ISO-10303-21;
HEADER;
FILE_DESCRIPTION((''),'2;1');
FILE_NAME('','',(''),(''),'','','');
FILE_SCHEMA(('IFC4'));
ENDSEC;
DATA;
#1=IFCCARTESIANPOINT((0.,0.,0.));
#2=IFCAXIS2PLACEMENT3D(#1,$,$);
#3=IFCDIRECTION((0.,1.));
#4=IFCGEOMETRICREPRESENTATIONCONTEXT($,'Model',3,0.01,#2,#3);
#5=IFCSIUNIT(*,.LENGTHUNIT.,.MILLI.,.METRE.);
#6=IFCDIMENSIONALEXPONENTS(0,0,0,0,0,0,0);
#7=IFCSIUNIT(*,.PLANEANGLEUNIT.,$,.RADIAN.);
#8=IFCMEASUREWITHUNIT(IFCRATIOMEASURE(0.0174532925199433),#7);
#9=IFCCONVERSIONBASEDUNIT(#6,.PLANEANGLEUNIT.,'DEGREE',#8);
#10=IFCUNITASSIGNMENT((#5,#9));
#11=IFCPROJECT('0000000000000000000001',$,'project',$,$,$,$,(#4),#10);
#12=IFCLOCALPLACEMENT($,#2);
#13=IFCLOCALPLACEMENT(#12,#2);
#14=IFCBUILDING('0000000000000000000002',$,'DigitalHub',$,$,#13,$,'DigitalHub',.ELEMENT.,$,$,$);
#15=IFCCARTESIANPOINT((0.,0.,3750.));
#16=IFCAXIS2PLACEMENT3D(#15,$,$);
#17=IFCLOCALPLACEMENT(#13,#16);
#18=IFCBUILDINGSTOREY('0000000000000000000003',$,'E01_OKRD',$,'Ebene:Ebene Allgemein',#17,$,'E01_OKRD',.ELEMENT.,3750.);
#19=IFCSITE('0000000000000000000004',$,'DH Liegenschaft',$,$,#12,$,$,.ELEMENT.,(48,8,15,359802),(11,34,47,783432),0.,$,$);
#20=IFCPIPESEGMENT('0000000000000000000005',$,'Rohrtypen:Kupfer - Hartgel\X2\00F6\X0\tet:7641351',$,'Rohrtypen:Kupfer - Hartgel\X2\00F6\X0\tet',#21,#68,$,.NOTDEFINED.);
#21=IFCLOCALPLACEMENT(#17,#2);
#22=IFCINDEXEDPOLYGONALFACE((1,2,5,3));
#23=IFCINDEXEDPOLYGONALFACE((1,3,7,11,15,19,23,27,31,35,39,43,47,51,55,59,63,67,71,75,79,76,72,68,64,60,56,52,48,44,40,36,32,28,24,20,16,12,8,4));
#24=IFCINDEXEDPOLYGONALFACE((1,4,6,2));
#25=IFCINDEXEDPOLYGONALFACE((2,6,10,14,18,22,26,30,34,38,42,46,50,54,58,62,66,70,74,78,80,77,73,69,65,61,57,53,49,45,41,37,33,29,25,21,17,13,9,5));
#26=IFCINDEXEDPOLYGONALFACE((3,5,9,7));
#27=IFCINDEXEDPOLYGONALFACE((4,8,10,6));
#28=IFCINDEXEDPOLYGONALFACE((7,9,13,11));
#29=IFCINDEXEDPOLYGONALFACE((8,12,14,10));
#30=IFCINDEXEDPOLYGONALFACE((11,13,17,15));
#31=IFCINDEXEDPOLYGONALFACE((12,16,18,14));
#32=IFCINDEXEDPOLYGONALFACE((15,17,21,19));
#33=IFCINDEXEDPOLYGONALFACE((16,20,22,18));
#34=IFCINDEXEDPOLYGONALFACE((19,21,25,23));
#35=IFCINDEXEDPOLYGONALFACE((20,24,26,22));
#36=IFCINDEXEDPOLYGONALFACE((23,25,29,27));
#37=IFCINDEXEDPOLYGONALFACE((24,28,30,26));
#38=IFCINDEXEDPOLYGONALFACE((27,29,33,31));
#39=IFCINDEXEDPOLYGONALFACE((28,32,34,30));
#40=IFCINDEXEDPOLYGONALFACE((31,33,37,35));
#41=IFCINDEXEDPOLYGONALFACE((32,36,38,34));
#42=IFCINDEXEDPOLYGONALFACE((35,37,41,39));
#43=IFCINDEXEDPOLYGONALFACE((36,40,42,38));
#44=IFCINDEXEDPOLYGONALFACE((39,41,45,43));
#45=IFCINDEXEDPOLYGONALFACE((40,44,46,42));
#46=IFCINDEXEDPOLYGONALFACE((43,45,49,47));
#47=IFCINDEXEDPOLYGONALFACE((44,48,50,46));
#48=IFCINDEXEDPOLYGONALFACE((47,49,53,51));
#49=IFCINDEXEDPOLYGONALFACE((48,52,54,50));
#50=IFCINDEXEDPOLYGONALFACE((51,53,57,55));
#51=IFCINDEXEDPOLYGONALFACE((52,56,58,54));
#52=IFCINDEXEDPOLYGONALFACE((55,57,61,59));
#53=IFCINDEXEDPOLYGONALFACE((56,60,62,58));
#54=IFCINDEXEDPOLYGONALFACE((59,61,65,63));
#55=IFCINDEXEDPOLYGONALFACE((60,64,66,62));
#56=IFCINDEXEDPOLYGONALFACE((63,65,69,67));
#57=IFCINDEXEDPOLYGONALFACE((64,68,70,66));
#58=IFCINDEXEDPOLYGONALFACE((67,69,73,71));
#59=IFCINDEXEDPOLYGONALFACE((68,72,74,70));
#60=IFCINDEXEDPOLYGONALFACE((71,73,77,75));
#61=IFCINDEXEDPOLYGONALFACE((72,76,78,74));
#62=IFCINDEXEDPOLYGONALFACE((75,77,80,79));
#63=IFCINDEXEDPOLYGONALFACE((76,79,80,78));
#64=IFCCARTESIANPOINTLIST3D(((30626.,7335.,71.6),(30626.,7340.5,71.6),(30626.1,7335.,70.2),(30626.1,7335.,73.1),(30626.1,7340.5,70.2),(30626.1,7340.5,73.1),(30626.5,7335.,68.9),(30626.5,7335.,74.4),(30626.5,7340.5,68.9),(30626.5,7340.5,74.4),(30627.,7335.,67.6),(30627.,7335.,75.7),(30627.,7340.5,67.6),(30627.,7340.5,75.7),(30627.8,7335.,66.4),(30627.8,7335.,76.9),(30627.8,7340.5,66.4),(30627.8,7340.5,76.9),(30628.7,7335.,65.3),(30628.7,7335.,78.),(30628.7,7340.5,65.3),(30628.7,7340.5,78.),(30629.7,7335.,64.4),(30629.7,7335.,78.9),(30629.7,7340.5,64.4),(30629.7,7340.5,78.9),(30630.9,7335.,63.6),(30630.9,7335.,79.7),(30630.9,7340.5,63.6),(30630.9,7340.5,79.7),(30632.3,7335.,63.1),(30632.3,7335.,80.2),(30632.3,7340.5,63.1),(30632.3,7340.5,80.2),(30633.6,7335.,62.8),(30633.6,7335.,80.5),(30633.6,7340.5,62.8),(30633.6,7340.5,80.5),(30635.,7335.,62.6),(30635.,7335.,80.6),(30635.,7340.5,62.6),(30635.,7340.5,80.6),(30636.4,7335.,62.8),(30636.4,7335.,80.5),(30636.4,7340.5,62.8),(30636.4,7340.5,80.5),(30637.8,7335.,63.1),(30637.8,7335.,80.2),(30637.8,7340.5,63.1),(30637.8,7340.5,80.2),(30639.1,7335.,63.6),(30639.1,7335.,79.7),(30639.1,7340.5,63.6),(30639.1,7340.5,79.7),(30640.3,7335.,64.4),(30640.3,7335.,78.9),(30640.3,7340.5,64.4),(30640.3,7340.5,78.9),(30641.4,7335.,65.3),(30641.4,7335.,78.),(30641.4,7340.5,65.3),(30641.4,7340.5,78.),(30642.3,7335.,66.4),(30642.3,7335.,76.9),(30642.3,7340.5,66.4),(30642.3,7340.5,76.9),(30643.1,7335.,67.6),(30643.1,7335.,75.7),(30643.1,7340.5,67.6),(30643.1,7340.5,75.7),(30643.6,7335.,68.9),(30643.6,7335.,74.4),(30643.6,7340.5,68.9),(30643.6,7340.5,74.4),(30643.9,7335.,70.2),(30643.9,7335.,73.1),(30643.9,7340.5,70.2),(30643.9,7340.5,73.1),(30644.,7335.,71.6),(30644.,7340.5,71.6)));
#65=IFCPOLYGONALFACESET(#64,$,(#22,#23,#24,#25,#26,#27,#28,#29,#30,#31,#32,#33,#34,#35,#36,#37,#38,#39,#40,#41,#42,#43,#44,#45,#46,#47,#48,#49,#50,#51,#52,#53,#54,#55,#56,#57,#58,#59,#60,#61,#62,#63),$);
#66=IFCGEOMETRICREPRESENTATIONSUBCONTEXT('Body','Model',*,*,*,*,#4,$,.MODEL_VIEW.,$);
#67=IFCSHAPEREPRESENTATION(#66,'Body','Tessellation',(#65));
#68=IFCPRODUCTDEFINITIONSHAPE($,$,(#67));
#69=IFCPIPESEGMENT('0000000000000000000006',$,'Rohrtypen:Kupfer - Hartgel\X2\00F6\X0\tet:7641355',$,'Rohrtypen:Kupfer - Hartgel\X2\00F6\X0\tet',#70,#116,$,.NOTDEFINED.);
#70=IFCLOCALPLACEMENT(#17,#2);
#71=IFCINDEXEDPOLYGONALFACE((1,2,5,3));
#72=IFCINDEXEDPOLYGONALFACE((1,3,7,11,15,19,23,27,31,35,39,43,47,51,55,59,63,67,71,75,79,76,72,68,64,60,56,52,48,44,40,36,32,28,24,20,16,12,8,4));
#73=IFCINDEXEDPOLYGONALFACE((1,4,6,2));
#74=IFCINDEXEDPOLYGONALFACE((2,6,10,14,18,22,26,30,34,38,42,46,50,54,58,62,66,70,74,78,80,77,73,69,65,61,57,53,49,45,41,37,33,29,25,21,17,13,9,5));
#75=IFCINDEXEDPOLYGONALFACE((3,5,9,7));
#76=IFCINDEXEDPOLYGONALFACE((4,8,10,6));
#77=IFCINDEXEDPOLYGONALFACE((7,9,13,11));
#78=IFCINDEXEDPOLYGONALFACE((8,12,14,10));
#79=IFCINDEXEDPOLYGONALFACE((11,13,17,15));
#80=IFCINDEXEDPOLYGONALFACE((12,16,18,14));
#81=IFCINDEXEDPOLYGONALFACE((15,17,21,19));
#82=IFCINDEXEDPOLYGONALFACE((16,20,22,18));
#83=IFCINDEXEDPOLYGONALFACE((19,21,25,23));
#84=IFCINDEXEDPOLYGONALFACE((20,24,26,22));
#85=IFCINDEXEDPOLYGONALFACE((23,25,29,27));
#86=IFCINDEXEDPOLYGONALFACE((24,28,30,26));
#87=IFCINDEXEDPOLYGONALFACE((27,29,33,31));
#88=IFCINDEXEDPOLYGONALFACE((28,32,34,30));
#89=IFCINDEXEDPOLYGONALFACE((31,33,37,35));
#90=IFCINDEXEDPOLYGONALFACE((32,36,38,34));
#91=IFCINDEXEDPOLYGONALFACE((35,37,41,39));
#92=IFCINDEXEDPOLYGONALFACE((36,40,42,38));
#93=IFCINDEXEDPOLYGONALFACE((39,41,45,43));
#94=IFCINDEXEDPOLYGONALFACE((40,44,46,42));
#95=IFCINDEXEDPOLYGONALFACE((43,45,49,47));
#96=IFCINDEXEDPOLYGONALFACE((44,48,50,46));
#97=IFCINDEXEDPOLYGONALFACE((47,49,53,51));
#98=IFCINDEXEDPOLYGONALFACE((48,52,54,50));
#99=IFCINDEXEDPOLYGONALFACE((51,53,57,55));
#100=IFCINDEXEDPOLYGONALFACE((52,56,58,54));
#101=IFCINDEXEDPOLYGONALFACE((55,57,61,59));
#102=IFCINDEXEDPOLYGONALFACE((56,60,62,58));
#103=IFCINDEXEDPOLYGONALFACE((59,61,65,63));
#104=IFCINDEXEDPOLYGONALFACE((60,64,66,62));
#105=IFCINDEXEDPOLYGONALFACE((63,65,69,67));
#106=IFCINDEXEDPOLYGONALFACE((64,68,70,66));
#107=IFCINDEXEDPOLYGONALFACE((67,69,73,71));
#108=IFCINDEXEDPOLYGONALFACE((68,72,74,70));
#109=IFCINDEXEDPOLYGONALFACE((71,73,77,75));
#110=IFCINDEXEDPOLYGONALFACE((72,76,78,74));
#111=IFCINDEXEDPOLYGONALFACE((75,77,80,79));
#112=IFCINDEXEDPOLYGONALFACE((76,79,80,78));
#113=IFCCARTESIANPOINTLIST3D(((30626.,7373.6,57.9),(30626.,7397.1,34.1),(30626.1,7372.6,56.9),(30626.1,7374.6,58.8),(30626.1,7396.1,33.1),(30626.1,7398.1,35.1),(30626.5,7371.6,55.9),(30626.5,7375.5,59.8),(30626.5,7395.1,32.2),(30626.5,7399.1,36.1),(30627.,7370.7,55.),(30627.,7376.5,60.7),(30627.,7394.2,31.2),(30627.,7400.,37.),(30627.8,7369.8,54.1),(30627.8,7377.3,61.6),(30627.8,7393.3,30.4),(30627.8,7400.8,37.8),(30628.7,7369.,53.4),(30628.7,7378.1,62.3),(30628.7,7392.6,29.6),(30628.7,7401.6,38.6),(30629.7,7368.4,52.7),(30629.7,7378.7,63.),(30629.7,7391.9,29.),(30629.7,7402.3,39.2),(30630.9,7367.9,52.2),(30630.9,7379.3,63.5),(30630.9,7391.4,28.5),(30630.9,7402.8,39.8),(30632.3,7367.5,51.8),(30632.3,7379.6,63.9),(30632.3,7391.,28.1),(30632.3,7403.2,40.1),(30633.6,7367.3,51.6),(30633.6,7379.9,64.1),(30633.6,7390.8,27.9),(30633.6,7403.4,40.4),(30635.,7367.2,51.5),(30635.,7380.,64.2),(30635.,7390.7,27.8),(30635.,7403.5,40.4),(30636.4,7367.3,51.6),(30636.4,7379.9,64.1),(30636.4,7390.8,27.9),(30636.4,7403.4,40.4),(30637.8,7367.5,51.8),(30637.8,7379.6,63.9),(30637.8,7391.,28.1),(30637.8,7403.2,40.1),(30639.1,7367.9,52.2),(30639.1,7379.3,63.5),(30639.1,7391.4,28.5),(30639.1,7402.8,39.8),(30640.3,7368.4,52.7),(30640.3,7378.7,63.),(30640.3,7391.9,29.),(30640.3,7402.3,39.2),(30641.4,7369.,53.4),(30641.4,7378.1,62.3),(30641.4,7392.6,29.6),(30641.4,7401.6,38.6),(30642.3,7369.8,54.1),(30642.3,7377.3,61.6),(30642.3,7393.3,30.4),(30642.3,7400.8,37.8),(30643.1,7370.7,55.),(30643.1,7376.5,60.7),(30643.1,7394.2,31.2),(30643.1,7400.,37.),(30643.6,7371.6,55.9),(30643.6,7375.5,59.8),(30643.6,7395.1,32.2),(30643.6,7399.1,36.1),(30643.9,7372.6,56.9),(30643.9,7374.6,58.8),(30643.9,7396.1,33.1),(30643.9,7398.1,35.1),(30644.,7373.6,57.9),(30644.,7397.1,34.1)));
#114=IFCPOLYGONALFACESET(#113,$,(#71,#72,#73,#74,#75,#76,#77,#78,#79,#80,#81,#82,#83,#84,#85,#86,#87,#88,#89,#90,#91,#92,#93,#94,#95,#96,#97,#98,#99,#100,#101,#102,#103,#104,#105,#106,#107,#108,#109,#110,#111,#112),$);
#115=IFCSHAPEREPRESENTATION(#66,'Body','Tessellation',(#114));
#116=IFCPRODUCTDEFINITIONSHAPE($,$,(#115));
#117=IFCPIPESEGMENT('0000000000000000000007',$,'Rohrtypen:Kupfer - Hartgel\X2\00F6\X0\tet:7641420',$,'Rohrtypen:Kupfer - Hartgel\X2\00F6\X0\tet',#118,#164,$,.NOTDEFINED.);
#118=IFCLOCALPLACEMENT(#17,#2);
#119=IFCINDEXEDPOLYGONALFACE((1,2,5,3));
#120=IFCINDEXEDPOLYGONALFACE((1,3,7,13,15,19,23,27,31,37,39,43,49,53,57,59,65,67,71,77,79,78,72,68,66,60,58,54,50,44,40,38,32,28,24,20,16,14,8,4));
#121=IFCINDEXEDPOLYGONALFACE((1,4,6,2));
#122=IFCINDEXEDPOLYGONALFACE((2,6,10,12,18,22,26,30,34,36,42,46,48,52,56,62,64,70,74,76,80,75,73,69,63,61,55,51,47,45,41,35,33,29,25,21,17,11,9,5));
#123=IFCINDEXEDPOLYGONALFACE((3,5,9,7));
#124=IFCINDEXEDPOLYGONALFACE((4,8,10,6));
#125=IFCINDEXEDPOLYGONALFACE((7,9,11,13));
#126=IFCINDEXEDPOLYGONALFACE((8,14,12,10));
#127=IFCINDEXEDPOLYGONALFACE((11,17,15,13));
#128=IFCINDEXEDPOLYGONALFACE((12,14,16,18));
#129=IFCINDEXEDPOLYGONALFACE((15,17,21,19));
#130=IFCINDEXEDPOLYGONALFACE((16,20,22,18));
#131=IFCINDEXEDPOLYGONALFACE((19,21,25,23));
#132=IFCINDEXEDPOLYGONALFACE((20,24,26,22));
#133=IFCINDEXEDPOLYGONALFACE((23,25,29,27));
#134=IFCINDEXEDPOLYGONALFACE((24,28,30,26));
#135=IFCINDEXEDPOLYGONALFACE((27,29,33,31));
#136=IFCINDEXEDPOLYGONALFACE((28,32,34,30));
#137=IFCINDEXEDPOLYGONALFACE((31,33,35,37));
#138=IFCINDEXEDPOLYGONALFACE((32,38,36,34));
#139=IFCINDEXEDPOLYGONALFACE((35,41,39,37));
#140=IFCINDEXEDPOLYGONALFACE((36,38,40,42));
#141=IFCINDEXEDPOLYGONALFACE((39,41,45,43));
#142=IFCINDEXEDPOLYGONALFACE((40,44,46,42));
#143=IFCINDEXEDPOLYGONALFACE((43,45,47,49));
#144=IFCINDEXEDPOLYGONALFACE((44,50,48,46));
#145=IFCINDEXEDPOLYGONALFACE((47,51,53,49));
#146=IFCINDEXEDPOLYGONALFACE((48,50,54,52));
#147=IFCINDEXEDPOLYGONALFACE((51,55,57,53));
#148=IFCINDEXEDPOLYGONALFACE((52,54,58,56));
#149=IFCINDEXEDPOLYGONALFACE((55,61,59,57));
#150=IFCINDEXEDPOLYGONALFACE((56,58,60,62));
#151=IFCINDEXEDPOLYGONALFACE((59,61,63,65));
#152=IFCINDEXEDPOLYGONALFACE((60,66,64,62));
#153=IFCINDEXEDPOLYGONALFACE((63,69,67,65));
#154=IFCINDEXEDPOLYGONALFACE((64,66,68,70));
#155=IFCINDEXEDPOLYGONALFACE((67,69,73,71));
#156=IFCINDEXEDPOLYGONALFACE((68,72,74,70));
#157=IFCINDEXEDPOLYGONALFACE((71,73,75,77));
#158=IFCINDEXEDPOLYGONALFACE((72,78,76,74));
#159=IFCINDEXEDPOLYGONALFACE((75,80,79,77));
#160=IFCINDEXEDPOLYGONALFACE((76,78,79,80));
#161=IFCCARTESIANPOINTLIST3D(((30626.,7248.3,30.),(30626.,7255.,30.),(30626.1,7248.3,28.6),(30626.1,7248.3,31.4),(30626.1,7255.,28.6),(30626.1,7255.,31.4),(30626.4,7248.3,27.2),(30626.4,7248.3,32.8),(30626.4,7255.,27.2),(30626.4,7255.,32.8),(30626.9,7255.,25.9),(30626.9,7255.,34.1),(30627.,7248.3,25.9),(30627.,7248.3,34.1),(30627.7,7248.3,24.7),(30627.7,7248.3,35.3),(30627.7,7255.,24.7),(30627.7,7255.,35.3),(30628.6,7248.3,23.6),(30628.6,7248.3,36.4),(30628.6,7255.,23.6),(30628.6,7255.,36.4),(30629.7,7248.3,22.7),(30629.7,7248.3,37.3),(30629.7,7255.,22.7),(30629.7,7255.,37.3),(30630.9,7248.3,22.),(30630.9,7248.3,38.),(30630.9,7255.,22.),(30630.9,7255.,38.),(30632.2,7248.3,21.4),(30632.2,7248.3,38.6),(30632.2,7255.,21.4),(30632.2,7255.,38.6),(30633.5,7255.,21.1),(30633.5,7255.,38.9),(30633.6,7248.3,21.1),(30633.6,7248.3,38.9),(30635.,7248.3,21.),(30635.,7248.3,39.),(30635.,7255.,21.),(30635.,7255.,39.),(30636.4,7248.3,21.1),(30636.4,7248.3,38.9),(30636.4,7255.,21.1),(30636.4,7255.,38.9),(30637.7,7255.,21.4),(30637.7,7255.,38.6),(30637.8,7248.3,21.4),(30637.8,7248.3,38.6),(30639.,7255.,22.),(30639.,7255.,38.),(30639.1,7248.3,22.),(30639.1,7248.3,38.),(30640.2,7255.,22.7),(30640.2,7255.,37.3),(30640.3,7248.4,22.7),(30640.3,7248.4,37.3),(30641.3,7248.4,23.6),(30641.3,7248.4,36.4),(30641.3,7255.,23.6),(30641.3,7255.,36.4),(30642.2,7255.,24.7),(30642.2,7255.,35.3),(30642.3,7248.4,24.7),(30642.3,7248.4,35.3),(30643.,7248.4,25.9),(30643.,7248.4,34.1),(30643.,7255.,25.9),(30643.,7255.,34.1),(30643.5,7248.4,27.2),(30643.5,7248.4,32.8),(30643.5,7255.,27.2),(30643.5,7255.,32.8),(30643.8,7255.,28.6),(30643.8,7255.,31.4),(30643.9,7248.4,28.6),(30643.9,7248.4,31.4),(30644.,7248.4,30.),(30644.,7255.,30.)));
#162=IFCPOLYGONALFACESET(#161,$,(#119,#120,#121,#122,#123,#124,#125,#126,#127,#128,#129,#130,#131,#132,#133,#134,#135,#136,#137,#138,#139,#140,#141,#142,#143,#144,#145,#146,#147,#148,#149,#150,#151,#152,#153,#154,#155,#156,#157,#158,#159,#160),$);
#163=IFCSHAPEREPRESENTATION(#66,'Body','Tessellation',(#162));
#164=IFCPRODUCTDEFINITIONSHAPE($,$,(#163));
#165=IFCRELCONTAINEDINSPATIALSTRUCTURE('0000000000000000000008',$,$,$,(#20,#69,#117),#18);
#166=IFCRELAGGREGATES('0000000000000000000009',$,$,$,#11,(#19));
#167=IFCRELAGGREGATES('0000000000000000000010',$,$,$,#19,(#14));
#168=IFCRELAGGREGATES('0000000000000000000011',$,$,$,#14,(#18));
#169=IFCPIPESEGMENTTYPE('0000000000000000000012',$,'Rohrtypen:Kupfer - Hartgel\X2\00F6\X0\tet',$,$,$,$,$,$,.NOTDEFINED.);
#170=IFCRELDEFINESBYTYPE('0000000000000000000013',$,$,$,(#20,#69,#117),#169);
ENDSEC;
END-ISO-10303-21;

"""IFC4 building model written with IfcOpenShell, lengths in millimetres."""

from ifc_helpers import new_model, entity, si_unit, converted_unit, direction, frame, origin, place, context, subcontext, project, spatial, indexed_curve, outline, extrude, type_object, element, save


model = new_model("IFC4")

# Units and contexts
model_context = context("Model", 3, precision=0.01, world=origin(), true_north=direction((0.0, 1.0)))
body_context = subcontext(model_context, "Body", "Model", "MODEL_VIEW")
ifc_project = project(units=[si_unit("LENGTHUNIT", "METRE", prefix="MILLI"), converted_unit("PLANEANGLEUNIT", "DEGREE", entity("IfcRatioMeasure", 0.0174532925199433), si_unit("PLANEANGLEUNIT", "RADIAN"), dimensions=[0, 0, 0, 0, 0, 0, 0])], contexts=[model_context])

# Site, building, storey
site_placement = place(None, origin())
site = spatial("IfcSite", under=ifc_project, at=site_placement, Name="DH Liegenschaft", CompositionType="ELEMENT", RefLatitude=(48, 8, 15, 359802), RefLongitude=(11, 34, 47, 783432), RefElevation=0.0)
building_placement = place(site_placement, origin())
building = spatial("IfcBuilding", under=site, at=building_placement, Name="DigitalHub", LongName="DigitalHub", CompositionType="ELEMENT")
storey_placement = place(building_placement, frame((0.0, 0.0, 3750.0)))
storey = spatial("IfcBuildingStorey", under=building, at=storey_placement, Name="E01_OKRD", ObjectType="Ebene:Ebene Allgemein", LongName="E01_OKRD", CompositionType="ELEMENT", Elevation=3750.0)

# Pipe segments
pipe_segment_type = type_object("IfcPipeSegmentType", Name="Rohrtypen:Kupfer - Hartgelötet", PredefinedType="NOTDEFINED")
pipe_segment_1_placement = place(storey_placement, frame((30624.4, 7335.0, 61.1)))
element("IfcPipeSegment", 1, at=pipe_segment_1_placement, inside=storey, type_object=pipe_segment_type, Name="Rohrtypen:Kupfer - Hartgelötet:7641351", ObjectType="Rohrtypen:Kupfer - Hartgelötet", PredefinedType="NOTDEFINED", context=body_context, shape_type="SweptSolid", body=[
    extrude(outline(indexed_curve([(9.0, 0.0), (8.9, 1.4), (8.6, 2.8), (8.0, 4.1), (7.3, 5.3), (6.4, 6.4), (5.3, 7.3), (4.1, 8.0), (2.8, 8.6), (1.4, 8.9), (0.0, 9.0), (-1.4, 8.9), (-2.8, 8.6), (-4.1, 8.0), (-5.3, 7.3), (-6.4, 6.4), (-7.3, 5.3), (-8.0, 4.1), (-8.6, 2.8), (-8.9, 1.4), (-9.0, 0.0), (-8.9, -1.4), (-8.6, -2.8), (-8.0, -4.1), (-7.3, -5.3), (-6.4, -6.4), (-5.3, -7.3), (-4.1, -8.0), (-2.8, -8.6), (-1.4, -8.9), (0.0, -9.0), (1.4, -8.9), (2.8, -8.6), (4.1, -8.0), (5.3, -7.3), (6.4, -6.4), (7.3, -5.3), (8.0, -4.1), (8.6, -2.8), (8.9, -1.4), (9.0, 0.0)], self_intersect=False)), frame((10.6, 0.0, 10.6), z_axis=(0.0, 1.0, 0.0), x_axis=(-1.0, 0.0, 0.0)), (0.0, 0.0, 1.0), 5.5),
])
pipe_segment_2_placement = place(storey_placement, frame((30624.4, 7365.6, 26.2)))
element("IfcPipeSegment", 2, at=pipe_segment_2_placement, inside=storey, type_object=pipe_segment_type, Name="Rohrtypen:Kupfer - Hartgelötet:7641355", ObjectType="Rohrtypen:Kupfer - Hartgelötet", PredefinedType="NOTDEFINED", context=body_context, shape_type="SweptSolid", body=[
    extrude(outline(indexed_curve([(9.0, 0.0), (8.9, 1.4), (8.6, 2.8), (8.0, 4.1), (7.3, 5.3), (6.4, 6.4), (5.3, 7.3), (4.1, 8.0), (2.8, 8.6), (1.4, 8.9), (0.0, 9.0), (-1.4, 8.9), (-2.8, 8.6), (-4.1, 8.0), (-5.3, 7.3), (-6.4, 6.4), (-7.3, 5.3), (-8.0, 4.1), (-8.6, 2.8), (-8.9, 1.4), (-9.0, 0.0), (-8.9, -1.4), (-8.6, -2.8), (-8.0, -4.1), (-7.3, -5.3), (-6.4, -6.4), (-5.3, -7.3), (-4.1, -8.0), (-2.8, -8.6), (-1.4, -8.9), (0.0, -9.0), (1.4, -8.9), (2.8, -8.6), (4.1, -8.0), (5.3, -7.3), (6.4, -6.4), (7.3, -5.3), (8.0, -4.1), (8.6, -2.8), (8.9, -1.4), (9.0, 0.0)], self_intersect=False)), frame((10.6, 8.0, 31.7), z_axis=(0.0, 0.70394, -0.71026), x_axis=(-1.0, 0.0, 0.0)), (0.0, 0.0, 1.0), 33.4),
])
pipe_segment_3_placement = place(storey_placement, frame((30624.4, 7248.3, 19.4)))
element("IfcPipeSegment", 3, at=pipe_segment_3_placement, inside=storey, type_object=pipe_segment_type, Name="Rohrtypen:Kupfer - Hartgelötet:7641420", ObjectType="Rohrtypen:Kupfer - Hartgelötet", PredefinedType="NOTDEFINED", context=body_context, shape_type="SweptSolid", body=[
    extrude(outline(indexed_curve([(9.0, 0.0), (8.9, 1.4), (8.6, 2.8), (8.0, 4.1), (7.3, 5.3), (6.4, 6.4), (5.3, 7.3), (4.1, 8.0), (2.8, 8.6), (1.4, 8.9), (0.0, 9.0), (-1.4, 8.9), (-2.8, 8.6), (-4.1, 8.0), (-5.3, 7.3), (-6.4, 6.4), (-7.3, 5.3), (-8.0, 4.1), (-8.6, 2.8), (-8.9, 1.4), (-9.0, 0.0), (-8.9, -1.4), (-8.6, -2.8), (-8.0, -4.1), (-7.3, -5.3), (-6.4, -6.4), (-5.3, -7.3), (-4.1, -8.0), (-2.8, -8.6), (-1.4, -8.9), (0.0, -9.0), (1.4, -8.9), (2.8, -8.6), (4.1, -8.0), (5.3, -7.3), (6.4, -6.4), (7.3, -5.3), (8.0, -4.1), (8.6, -2.8), (8.9, -1.4), (9.0, 0.0)], self_intersect=False)), frame((10.6, 0.0, 10.6), z_axis=(-0.001885, 0.999998, 0.0), x_axis=(-0.999998, -0.001885, 0.0)), (0.0, 0.0, 1.0), 6.6),
])

save(model, "model.ifc")
